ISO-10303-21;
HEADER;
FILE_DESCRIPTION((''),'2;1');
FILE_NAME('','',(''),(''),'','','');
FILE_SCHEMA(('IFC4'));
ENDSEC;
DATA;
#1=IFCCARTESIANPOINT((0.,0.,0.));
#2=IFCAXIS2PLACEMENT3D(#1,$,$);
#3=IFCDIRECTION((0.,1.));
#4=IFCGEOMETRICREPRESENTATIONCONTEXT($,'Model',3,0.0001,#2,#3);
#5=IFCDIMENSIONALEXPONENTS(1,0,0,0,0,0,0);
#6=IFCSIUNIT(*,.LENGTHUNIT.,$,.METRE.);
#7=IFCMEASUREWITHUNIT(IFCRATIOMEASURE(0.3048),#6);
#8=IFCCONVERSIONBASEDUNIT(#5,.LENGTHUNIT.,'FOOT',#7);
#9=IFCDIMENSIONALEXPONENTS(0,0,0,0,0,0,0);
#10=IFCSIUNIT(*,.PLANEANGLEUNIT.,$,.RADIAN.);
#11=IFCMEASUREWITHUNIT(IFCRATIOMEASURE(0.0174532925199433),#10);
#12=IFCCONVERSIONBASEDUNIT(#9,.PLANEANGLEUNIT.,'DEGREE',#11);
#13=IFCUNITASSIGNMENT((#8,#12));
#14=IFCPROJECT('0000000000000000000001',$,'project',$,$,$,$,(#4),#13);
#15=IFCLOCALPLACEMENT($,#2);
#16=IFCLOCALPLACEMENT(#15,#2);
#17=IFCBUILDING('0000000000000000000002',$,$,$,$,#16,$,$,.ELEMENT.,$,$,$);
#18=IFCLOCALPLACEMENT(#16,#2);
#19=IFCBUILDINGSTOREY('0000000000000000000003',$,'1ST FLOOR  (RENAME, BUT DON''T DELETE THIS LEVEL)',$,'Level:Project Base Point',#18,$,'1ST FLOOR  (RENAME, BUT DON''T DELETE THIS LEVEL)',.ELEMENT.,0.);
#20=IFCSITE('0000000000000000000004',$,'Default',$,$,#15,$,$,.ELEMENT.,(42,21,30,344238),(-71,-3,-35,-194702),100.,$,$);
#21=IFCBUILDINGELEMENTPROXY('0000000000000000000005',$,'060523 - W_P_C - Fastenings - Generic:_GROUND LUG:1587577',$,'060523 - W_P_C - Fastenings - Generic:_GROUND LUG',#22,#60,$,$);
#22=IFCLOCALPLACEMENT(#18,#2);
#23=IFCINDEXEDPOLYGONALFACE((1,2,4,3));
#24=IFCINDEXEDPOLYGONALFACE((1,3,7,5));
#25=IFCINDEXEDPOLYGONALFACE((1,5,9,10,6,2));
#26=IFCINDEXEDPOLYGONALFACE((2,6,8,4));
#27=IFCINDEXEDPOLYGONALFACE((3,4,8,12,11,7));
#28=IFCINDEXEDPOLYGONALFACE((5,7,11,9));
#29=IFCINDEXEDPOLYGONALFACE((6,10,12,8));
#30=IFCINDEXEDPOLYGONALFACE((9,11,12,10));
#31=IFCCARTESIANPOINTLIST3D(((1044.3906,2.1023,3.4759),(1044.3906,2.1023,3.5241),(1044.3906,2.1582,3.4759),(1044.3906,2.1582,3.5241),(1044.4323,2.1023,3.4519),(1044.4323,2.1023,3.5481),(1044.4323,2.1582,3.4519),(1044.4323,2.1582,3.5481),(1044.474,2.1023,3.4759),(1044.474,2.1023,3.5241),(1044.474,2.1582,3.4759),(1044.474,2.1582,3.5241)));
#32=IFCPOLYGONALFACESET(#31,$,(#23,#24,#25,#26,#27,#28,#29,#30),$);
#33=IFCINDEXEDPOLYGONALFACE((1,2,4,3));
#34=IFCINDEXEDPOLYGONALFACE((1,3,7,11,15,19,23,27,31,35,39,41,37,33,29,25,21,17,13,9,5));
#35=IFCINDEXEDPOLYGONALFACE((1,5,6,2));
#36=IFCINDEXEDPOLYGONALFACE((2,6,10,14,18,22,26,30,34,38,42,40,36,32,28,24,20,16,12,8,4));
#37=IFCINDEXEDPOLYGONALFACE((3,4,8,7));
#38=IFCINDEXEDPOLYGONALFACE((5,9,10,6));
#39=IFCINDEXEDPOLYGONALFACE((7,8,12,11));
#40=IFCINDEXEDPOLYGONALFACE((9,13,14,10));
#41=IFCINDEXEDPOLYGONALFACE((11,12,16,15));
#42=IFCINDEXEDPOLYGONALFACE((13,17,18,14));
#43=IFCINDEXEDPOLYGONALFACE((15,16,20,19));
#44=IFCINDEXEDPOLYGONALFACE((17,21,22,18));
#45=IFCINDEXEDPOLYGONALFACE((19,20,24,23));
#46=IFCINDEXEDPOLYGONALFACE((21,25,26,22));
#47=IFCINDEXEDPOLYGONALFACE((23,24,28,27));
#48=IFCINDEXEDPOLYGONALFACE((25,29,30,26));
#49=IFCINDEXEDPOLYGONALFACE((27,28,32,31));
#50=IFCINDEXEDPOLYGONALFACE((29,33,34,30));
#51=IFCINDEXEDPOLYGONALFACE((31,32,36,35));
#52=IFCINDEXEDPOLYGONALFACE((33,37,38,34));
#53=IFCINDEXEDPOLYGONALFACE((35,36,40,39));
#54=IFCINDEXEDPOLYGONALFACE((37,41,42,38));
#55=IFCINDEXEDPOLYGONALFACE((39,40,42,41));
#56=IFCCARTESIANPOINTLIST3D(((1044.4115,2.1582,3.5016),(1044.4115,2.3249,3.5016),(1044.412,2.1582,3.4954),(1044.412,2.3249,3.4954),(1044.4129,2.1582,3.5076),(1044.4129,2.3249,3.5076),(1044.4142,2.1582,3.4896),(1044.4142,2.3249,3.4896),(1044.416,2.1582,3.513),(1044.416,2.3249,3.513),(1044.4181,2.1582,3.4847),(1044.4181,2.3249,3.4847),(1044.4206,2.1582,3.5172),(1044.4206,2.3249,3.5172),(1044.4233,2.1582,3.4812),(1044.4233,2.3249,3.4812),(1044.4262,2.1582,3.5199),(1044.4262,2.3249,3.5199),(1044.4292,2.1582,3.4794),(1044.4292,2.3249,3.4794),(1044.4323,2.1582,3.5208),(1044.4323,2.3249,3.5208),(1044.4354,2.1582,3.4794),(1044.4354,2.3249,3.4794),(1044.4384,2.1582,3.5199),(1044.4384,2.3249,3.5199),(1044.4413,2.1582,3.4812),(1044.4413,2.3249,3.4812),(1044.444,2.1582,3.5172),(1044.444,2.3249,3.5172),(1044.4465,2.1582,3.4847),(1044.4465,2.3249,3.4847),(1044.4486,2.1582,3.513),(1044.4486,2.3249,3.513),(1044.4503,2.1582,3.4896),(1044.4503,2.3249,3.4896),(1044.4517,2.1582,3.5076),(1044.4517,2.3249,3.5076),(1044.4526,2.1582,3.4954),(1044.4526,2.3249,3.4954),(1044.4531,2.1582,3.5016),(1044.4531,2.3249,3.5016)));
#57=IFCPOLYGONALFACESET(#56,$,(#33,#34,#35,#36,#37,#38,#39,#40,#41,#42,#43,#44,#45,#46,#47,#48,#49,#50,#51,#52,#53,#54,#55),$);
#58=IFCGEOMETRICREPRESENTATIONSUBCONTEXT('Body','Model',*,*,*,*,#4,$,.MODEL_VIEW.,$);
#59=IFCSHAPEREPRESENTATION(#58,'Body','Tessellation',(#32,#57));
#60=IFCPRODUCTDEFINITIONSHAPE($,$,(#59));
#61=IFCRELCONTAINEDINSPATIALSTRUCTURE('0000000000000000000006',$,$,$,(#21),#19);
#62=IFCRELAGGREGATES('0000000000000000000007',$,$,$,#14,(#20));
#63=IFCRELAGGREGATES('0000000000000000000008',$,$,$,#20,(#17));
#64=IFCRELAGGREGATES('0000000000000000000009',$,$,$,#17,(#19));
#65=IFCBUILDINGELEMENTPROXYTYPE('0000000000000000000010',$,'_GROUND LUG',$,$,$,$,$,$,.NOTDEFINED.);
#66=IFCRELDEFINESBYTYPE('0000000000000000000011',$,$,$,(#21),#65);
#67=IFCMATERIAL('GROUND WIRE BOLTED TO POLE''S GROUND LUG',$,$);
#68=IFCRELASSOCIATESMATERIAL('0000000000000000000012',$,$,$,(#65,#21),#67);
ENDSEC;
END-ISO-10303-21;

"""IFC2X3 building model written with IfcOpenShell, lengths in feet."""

from ifc_helpers import new_model, entity, si_unit, converted_unit, direction, frame, frame_2d, origin, place, context, subcontext, project, spatial, polyline, circle, outline, extrude, source, transform, mapped, material, type_object, type_shapes, element, save


model = new_model("IFC2X3")

# Units and contexts
model_context = context("Model", 3, precision=0.0001, world=origin(), true_north=direction((0.0, 1.0)))
body_context = subcontext(model_context, "Body", "Model", "MODEL_VIEW")
ifc_project = project(units=[converted_unit("LENGTHUNIT", "FOOT", entity("IfcRatioMeasure", 0.3048), si_unit("LENGTHUNIT", "METRE"), dimensions=[1, 0, 0, 0, 0, 0, 0]), converted_unit("PLANEANGLEUNIT", "DEGREE", entity("IfcRatioMeasure", 0.0174532925199433), si_unit("PLANEANGLEUNIT", "RADIAN"), dimensions=[0, 0, 0, 0, 0, 0, 0])], contexts=[model_context])

# Site, building, storey
site_placement = place(None, origin())
site = spatial("IfcSite", under=ifc_project, at=site_placement, Name="Default", CompositionType="ELEMENT", RefLatitude=(42, 21, 30, 344238), RefLongitude=(-71, -3, -35, -194702), RefElevation=100.0)
building_placement = place(site_placement, origin())
building = spatial("IfcBuilding", under=site, at=building_placement, CompositionType="ELEMENT")
storey_placement = place(building_placement, origin())
storey = spatial("IfcBuildingStorey", under=building, at=storey_placement, Name="1ST FLOOR  (RENAME, BUT DON'T DELETE THIS LEVEL)", ObjectType="Level:Project Base Point", LongName="1ST FLOOR  (RENAME, BUT DON'T DELETE THIS LEVEL)", CompositionType="ELEMENT", Elevation=0.0)

# Building element proxy
ifc_material_1 = material(Name="GROUND WIRE BOLTED TO POLE'S GROUND LUG")
building_element_proxy_type_1 = type_object("IfcBuildingElementProxyType", Name="_GROUND LUG", PredefinedType="NOTDEFINED", material=ifc_material_1)
shared_shape_1 = source(origin(), body_context, "Body", "SweptSolid", [
    extrude(outline(polyline([(-0.0241, -0.0417), (0.0241, -0.0417), (0.0481, 0.0), (0.0241, 0.0417), (-0.0241, 0.0417), (-0.0481, 0.0), (-0.0241, -0.0417)])), frame((0.0, 0.0, 0.0), z_axis=(0.0, 0.0, 1.0), x_axis=(0.0, -1.0, 0.0)), (0.0, 0.0, 1.0), 0.056),
    extrude(circle(Radius=0.0208, at=frame_2d((0.0, 0.0), x_axis=(1.0, 0.0))), frame((0.0, 0.0, -0.1667), z_axis=(0.0, 0.0, 1.0), x_axis=(0.0, 1.0, 0.0)), (0.0, 0.0, 1.0), 0.1667),
])
type_shapes(building_element_proxy_type_1, [shared_shape_1])
proxy_1_placement = place(storey_placement, frame((1044.4323, 2.1582, 3.5), z_axis=(0.0, -1.0, 0.0), x_axis=(1.0, 0.0, 0.0)))
element("IfcBuildingElementProxy", 1, at=proxy_1_placement, inside=storey, type_object=building_element_proxy_type_1, material=ifc_material_1, Name="060523 - W_P_C - Fastenings - Generic:_GROUND LUG:1587577", ObjectType="060523 - W_P_C - Fastenings - Generic:_GROUND LUG", context=body_context, shape_type="MappedRepresentation", body=[
    mapped(shared_shape_1, transform((0.0, 0.0, 0.0), scale=1.0)),
])

save(model, "model.ifc")
